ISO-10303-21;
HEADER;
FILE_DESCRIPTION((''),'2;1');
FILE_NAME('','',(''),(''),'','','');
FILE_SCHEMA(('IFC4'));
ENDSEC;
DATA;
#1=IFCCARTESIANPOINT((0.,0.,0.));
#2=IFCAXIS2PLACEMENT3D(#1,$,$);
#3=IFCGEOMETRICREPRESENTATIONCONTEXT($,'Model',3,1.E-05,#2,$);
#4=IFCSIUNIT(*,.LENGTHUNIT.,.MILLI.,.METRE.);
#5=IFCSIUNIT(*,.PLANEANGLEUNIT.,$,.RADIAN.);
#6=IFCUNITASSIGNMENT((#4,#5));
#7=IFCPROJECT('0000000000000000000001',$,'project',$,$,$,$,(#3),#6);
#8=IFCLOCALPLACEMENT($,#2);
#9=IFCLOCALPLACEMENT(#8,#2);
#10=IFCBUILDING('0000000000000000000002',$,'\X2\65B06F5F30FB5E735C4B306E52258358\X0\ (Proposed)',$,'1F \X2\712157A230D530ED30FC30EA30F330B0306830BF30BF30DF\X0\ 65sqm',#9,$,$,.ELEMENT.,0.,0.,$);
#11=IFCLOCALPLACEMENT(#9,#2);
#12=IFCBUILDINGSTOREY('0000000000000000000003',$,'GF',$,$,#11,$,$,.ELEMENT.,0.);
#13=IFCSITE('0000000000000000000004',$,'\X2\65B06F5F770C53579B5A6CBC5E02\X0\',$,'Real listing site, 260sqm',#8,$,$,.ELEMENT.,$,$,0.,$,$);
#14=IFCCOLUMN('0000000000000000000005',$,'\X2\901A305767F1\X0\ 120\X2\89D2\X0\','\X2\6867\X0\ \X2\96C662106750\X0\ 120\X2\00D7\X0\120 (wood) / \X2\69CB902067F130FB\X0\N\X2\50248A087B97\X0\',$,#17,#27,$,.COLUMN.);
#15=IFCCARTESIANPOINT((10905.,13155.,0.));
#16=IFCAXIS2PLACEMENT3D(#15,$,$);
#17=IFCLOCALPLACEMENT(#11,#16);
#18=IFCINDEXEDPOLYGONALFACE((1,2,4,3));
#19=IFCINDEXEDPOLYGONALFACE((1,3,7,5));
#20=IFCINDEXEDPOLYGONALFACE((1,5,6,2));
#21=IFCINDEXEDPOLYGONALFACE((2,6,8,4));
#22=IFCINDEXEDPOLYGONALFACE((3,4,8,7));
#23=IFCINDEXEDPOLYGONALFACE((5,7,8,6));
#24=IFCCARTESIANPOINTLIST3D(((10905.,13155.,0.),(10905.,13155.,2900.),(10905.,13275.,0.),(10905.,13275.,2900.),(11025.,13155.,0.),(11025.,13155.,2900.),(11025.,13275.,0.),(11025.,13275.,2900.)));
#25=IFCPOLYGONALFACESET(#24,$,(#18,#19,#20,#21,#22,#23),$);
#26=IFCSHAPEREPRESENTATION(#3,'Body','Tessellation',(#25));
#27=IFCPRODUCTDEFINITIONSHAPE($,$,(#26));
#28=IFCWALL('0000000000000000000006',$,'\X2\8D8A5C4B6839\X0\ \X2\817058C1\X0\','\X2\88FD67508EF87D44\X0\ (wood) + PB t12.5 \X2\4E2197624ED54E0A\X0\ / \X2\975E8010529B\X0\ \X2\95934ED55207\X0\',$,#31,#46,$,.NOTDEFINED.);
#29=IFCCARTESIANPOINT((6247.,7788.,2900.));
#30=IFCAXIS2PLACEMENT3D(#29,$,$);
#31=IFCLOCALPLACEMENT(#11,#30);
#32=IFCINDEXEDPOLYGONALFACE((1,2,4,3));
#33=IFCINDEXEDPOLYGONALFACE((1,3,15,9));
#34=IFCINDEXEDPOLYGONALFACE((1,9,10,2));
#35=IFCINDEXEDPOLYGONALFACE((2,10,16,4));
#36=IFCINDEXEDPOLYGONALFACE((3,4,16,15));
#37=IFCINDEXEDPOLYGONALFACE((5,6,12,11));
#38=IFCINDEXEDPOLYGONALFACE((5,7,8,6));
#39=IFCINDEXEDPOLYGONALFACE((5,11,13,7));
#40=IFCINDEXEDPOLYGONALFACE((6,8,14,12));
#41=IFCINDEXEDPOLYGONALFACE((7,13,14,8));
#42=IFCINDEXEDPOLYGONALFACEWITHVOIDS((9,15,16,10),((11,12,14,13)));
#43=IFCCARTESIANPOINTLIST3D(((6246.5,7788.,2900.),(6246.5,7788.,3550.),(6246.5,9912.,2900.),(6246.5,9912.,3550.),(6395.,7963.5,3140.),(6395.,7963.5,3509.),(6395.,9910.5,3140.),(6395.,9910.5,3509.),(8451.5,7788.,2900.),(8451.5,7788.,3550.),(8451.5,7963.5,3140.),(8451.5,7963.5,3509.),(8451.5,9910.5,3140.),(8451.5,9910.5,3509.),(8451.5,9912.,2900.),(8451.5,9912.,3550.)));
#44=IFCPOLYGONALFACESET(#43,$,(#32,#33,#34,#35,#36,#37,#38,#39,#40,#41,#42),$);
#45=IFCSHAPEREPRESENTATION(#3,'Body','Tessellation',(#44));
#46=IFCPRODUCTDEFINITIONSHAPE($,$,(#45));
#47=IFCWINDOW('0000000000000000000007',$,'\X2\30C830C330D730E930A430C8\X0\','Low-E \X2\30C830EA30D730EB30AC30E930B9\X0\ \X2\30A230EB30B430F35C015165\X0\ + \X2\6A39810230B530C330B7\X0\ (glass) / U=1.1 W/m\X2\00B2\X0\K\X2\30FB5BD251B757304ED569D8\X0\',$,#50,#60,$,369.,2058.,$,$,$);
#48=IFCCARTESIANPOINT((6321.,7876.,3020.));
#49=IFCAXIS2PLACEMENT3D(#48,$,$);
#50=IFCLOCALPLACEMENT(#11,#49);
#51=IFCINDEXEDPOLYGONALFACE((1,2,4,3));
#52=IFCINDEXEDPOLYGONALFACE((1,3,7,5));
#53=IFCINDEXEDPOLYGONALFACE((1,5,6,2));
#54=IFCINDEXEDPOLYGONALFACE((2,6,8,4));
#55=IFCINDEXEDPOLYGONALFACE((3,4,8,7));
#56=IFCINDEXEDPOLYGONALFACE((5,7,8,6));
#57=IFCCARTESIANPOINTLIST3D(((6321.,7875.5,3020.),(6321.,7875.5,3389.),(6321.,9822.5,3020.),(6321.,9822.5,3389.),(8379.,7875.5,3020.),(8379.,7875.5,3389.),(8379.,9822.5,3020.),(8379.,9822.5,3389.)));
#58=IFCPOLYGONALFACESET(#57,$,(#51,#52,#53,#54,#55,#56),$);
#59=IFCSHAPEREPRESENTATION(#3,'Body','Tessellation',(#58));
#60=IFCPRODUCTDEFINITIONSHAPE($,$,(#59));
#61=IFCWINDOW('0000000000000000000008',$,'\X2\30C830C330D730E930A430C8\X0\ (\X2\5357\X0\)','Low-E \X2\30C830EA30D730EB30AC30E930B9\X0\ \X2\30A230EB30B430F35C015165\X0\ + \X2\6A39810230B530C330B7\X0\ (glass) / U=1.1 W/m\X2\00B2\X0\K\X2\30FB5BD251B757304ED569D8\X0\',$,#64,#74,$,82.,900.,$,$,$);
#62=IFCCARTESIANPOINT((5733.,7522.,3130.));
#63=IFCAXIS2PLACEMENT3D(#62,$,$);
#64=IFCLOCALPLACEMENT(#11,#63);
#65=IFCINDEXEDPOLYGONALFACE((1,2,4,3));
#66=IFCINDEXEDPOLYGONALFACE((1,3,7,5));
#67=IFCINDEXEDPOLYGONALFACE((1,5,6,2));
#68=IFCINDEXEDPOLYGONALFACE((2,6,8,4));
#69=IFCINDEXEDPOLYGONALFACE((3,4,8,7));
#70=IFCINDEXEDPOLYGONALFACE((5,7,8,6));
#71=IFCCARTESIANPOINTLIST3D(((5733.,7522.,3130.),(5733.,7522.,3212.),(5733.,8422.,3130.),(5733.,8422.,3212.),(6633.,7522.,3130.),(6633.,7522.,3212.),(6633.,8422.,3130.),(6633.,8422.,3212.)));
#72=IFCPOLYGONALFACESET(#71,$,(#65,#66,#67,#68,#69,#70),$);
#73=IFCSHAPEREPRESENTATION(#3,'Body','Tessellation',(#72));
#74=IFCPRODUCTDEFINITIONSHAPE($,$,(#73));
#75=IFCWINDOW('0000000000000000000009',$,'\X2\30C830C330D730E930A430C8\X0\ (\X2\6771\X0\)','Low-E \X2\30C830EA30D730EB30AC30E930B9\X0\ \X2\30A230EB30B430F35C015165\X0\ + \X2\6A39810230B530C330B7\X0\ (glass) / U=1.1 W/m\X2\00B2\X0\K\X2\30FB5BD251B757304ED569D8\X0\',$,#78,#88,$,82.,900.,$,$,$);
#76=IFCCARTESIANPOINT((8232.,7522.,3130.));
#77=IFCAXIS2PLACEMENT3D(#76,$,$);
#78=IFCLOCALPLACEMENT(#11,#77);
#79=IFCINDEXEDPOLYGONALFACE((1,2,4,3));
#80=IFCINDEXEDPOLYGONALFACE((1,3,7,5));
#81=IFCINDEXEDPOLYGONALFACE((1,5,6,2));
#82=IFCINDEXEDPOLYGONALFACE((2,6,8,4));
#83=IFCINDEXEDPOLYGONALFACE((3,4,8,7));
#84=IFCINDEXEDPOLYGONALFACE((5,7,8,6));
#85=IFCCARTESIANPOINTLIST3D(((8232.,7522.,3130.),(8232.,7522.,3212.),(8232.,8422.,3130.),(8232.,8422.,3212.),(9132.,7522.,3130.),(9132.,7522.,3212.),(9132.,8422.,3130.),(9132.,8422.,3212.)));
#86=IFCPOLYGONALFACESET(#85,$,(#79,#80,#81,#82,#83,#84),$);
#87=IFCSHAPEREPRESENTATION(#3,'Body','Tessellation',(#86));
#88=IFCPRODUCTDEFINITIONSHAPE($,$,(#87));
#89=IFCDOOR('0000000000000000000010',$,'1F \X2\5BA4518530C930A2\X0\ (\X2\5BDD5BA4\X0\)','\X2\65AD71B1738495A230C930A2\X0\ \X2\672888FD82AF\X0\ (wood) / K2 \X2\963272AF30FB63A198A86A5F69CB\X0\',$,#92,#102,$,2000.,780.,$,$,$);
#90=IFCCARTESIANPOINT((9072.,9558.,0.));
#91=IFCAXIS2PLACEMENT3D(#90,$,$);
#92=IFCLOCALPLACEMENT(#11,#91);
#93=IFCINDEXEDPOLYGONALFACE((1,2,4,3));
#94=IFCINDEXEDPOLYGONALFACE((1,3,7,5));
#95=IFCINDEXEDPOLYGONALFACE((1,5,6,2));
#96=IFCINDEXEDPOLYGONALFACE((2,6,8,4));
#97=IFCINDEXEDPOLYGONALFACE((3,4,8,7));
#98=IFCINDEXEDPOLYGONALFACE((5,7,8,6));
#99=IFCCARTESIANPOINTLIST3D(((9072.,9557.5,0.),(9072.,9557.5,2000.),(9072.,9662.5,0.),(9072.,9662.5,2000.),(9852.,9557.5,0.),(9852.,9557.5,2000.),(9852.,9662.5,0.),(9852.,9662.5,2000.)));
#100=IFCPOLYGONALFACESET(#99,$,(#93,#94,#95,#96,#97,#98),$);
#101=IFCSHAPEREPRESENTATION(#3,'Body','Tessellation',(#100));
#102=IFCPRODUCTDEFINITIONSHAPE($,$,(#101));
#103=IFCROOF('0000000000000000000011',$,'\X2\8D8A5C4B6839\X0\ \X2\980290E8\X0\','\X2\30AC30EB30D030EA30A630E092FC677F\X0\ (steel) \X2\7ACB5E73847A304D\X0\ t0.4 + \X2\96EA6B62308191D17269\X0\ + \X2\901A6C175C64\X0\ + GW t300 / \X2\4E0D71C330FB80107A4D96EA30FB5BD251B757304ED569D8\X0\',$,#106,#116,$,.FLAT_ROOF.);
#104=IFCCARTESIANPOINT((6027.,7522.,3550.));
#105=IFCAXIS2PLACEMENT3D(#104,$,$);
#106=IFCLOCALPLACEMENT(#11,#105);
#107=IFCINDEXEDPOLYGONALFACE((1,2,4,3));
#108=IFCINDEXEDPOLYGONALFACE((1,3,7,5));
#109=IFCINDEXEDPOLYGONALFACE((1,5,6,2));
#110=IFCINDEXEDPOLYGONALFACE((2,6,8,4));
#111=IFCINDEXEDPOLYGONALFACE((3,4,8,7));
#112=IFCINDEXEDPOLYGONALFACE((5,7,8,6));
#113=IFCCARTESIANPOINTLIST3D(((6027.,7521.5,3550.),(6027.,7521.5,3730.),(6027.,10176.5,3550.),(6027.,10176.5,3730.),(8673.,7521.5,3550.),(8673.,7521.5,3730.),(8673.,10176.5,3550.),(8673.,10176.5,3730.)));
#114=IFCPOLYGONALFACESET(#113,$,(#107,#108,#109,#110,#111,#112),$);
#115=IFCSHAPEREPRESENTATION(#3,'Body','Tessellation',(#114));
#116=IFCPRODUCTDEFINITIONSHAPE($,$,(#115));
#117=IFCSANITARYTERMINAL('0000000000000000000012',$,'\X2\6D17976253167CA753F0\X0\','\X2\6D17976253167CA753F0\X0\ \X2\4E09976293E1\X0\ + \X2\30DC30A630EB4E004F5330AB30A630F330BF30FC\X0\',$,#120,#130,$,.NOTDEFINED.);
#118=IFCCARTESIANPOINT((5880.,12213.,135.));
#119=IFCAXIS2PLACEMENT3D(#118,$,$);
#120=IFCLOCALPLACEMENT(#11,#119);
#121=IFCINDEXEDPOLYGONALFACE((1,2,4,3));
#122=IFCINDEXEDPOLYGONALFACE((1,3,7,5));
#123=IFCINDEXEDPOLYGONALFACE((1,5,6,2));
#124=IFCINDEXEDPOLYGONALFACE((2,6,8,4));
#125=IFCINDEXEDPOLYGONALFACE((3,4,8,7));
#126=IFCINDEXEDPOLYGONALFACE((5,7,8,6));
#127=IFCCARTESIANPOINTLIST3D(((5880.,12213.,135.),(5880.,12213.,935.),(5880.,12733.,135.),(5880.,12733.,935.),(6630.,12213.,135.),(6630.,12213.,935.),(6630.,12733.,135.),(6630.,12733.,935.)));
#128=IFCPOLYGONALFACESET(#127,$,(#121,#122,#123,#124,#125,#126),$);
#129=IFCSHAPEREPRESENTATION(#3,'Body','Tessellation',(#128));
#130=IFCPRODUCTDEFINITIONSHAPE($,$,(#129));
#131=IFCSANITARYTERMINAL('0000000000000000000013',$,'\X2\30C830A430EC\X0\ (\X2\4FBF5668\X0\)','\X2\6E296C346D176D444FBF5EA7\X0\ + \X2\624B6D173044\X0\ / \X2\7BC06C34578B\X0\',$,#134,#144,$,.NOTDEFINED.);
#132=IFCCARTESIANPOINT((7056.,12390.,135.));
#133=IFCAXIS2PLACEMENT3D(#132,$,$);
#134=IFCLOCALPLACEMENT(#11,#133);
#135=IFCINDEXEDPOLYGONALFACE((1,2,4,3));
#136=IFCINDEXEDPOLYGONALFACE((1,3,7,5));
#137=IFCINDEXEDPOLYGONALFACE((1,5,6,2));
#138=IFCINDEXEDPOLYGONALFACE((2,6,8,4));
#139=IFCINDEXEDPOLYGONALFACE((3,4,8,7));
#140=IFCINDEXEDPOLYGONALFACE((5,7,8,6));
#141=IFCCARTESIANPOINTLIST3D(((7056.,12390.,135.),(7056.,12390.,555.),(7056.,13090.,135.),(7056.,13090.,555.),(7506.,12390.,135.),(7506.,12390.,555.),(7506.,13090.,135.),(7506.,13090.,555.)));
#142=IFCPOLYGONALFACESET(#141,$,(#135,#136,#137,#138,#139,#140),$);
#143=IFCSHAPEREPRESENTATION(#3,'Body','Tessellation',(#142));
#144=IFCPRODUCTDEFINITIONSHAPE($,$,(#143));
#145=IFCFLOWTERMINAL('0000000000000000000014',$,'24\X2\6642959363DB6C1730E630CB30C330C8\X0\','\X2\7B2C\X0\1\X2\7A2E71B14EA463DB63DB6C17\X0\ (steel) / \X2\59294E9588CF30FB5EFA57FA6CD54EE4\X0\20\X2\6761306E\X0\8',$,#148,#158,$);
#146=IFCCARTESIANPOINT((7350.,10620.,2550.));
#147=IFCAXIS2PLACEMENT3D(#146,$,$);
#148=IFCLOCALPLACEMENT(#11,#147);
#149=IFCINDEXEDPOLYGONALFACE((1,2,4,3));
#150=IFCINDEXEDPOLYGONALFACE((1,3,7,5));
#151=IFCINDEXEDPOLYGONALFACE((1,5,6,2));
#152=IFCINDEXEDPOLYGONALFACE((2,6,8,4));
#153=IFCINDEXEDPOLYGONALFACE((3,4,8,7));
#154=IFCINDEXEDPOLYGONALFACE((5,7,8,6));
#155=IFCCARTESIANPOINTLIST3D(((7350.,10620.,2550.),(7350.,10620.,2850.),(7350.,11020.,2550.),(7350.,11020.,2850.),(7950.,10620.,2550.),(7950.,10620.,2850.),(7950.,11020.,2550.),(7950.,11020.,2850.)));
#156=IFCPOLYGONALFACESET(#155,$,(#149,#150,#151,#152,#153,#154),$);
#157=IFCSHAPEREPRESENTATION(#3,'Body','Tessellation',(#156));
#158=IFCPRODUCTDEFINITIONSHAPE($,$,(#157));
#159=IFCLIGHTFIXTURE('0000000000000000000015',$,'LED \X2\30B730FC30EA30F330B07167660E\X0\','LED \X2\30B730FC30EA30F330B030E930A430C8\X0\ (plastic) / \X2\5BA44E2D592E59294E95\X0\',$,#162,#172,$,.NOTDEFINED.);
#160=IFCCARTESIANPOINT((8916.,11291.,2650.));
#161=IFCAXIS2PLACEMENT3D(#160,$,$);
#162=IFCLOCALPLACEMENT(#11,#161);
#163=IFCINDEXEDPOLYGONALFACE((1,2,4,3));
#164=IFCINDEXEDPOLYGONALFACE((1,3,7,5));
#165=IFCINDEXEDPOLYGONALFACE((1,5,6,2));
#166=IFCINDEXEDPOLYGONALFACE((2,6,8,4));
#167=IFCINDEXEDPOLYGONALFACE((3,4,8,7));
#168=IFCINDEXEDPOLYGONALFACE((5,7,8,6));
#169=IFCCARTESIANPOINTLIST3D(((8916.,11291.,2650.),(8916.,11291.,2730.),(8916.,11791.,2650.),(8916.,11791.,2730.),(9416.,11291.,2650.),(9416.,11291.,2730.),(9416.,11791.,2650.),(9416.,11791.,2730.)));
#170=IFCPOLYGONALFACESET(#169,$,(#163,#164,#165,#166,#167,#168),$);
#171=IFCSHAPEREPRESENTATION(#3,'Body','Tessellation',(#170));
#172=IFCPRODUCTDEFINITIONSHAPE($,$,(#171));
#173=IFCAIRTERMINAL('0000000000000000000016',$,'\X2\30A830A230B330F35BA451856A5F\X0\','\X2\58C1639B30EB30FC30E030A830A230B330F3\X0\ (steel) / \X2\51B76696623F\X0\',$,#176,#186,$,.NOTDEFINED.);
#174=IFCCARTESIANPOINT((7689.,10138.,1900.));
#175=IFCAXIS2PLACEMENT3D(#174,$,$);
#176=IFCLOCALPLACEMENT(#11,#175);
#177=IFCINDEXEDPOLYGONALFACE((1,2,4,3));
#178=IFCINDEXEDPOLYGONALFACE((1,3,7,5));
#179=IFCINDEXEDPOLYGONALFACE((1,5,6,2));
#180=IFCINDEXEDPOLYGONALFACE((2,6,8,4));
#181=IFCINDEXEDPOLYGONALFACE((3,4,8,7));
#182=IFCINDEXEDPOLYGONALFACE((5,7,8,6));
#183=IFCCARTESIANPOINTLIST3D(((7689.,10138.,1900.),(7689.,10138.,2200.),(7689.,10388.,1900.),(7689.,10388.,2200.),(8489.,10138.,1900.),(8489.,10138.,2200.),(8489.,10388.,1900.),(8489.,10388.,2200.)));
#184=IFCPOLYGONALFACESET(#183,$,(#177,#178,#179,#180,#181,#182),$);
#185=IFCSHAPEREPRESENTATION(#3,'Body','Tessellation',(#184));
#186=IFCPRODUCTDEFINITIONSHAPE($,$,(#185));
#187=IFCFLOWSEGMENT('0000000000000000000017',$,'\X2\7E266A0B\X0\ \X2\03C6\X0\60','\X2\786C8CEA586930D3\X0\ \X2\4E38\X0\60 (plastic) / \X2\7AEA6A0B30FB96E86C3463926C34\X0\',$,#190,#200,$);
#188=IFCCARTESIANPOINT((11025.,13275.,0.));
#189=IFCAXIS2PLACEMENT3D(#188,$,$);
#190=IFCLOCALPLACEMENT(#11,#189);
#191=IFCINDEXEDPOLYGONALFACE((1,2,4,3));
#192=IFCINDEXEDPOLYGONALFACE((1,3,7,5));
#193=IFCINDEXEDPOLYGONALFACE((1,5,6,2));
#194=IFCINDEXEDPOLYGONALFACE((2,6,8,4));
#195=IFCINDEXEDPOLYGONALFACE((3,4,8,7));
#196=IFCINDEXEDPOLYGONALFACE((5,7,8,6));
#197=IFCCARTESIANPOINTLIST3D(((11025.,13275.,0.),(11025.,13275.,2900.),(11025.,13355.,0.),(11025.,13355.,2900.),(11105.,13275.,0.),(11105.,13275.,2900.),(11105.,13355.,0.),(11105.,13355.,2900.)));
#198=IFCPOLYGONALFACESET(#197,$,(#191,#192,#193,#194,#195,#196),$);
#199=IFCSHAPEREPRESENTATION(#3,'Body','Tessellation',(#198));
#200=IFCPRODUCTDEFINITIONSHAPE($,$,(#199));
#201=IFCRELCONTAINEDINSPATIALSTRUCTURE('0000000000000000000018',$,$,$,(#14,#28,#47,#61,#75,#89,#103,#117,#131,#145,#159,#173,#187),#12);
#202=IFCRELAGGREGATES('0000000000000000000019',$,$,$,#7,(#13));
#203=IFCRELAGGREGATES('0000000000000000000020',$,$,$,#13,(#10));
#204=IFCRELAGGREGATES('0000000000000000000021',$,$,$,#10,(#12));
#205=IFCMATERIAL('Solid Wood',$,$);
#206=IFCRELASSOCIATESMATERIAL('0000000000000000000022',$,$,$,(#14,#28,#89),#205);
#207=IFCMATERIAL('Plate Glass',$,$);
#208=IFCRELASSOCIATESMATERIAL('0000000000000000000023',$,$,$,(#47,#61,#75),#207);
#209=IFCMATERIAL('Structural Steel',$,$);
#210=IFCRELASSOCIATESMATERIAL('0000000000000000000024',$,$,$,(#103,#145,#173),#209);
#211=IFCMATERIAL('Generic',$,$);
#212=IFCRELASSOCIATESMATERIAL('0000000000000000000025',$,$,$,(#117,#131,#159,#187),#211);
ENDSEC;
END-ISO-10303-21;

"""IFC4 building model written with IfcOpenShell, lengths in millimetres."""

from ifc_helpers import new_model, si_unit, frame, frame_2d, origin, place, context, project, spatial, rectangle, extrude, material, element, fill, save


model = new_model("IFC4")

# Units and contexts
model_context = context("Model", 3, precision=1e-05, world=origin())
ifc_project = project(units=[si_unit("LENGTHUNIT", "METRE", prefix="MILLI"), si_unit("PLANEANGLEUNIT", "RADIAN")], contexts=[model_context])

# Site, building, storey
site_placement = place(None, origin())
site = spatial("IfcSite", under=ifc_project, at=site_placement, Name="新潟県南魚沼市", ObjectType="Real listing site, 260sqm", CompositionType="ELEMENT", RefElevation=0.0)
building_placement = place(site_placement, origin())
building = spatial("IfcBuilding", under=site, at=building_placement, Name="新潟・平屋の別荘 (Proposed)", ObjectType="1F 無垢フローリングとタタミ 65sqm", CompositionType="ELEMENT", ElevationOfRefHeight=0.0, ElevationOfTerrain=0.0)
storey_placement = place(building_placement, origin())
storey = spatial("IfcBuildingStorey", under=building, at=storey_placement, Name="GF", CompositionType="ELEMENT", Elevation=0.0)

# Column
ifc_material_1 = material(Name="Solid Wood")
column_1_placement = place(storey_placement, frame((10905.0, 13155.0, 0.0)))
element("IfcColumn", 1, at=column_1_placement, inside=storey, material=ifc_material_1, Name="通し柱 120角", Description="桧 集成材 120×120 (wood) / 構造柱・N値計算", PredefinedType="COLUMN", context=model_context, shape_type="SweptSolid", body=[
    extrude(rectangle(XDim=120.0, YDim=120.0, at=frame_2d((60.0, 60.0))), frame((10905.0, 13155.0, 0.0)), (0.0, 0.0, 1.0), 2900.0),
])

# Wall, openings, windows
wall_1_placement = place(storey_placement, frame((6247.0, 7788.0, 2900.0)))
wall_1 = element("IfcWall", 2, at=wall_1_placement, inside=storey, material=ifc_material_1, Name="越屋根 腰壁", Description="製材軸組 (wood) + PB t12.5 両面仕上 / 非耐力 間仕切", PredefinedType="NOTDEFINED", context=model_context, shape_type="SweptSolid", body=[
    extrude(rectangle(XDim=2205.0, YDim=2124.0, at=frame_2d((1102.0, 1062.0))), frame((6247.0, 7788.0, 2900.0)), (0.0, 0.0, 1.0), 650.0),
])
opening_1_placement = place(storey_placement, frame((6321.0, 7876.0, 3020.0)))
opening_1 = element("IfcOpeningElement", 3, at=opening_1_placement, cuts=wall_1, PredefinedType="NOTDEFINED", context=model_context, shape_type="SweptSolid", body=[
    extrude(rectangle(XDim=2058.0, YDim=1947.0, at=frame_2d((1029.0, 973.0))), frame((6321.0, 7876.0, 3020.0)), (0.0, 0.0, 1.0), 369.0),
])
opening_2_placement = place(storey_placement, frame((5733.0, 7522.0, 3130.0)))
opening_2 = element("IfcOpeningElement", 4, at=opening_2_placement, cuts=wall_1, PredefinedType="NOTDEFINED", context=model_context, shape_type="SweptSolid", body=[
    extrude(rectangle(XDim=900.0, YDim=900.0, at=frame_2d((450.0, 450.0))), frame((5733.0, 7522.0, 3130.0)), (0.0, 0.0, 1.0), 82.0),
])
opening_3_placement = place(storey_placement, frame((8232.0, 7522.0, 3130.0)))
opening_3 = element("IfcOpeningElement", 5, at=opening_3_placement, cuts=wall_1, PredefinedType="NOTDEFINED", context=model_context, shape_type="SweptSolid", body=[
    extrude(rectangle(XDim=900.0, YDim=900.0, at=frame_2d((450.0, 450.0))), frame((8232.0, 7522.0, 3130.0)), (0.0, 0.0, 1.0), 82.0),
])
ifc_material_2 = material(Name="Plate Glass")
window_1_placement = place(storey_placement, frame((6321.0, 7876.0, 3020.0)))
window_1 = element("IfcWindow", 6, at=window_1_placement, inside=storey, material=ifc_material_2, Name="トップライト", Description="Low-E トリプルガラス アルゴン封入 + 樹脂サッシ (glass) / U=1.1 W/m²K・寒冷地仕様", OverallHeight=369.0, OverallWidth=2058.0, context=model_context, shape_type="SweptSolid", body=[
    extrude(rectangle(XDim=2058.0, YDim=1947.0, at=frame_2d((1029.0, 973.0))), frame((6321.0, 7876.0, 3020.0)), (0.0, 0.0, 1.0), 369.0),
])
fill(opening_1, window_1)
window_2_placement = place(storey_placement, frame((5733.0, 7522.0, 3130.0)))
window_2 = element("IfcWindow", 7, at=window_2_placement, inside=storey, material=ifc_material_2, Name="トップライト (南)", Description="Low-E トリプルガラス アルゴン封入 + 樹脂サッシ (glass) / U=1.1 W/m²K・寒冷地仕様", OverallHeight=82.0, OverallWidth=900.0, context=model_context, shape_type="SweptSolid", body=[
    extrude(rectangle(XDim=900.0, YDim=900.0, at=frame_2d((450.0, 450.0))), frame((5733.0, 7522.0, 3130.0)), (0.0, 0.0, 1.0), 82.0),
])
fill(opening_2, window_2)
window_3_placement = place(storey_placement, frame((8232.0, 7522.0, 3130.0)))
window_3 = element("IfcWindow", 8, at=window_3_placement, inside=storey, material=ifc_material_2, Name="トップライト (東)", Description="Low-E トリプルガラス アルゴン封入 + 樹脂サッシ (glass) / U=1.1 W/m²K・寒冷地仕様", OverallHeight=82.0, OverallWidth=900.0, context=model_context, shape_type="SweptSolid", body=[
    extrude(rectangle(XDim=900.0, YDim=900.0, at=frame_2d((450.0, 450.0))), frame((8232.0, 7522.0, 3130.0)), (0.0, 0.0, 1.0), 82.0),
])
fill(opening_3, window_3)

# Door
door_placement = place(storey_placement, frame((9072.0, 9558.0, 0.0)))
element("IfcDoor", 9, at=door_placement, inside=storey, material=ifc_material_1, Name="1F 室内ドア (寝室)", Description="断熱玄関ドア 木製芯 (wood) / K2 防犯・採風機構", OverallHeight=2000.0, OverallWidth=780.0, context=model_context, shape_type="SweptSolid", body=[
    extrude(rectangle(XDim=780.0, YDim=105.0, at=frame_2d((390.0, 52.0))), frame((9072.0, 9558.0, 0.0)), (0.0, 0.0, 1.0), 2000.0),
])

# Roof
ifc_material_3 = material(Name="Structural Steel")
roof_placement = place(storey_placement, frame((6027.0, 7522.0, 3550.0)))
element("IfcRoof", 10, at=roof_placement, inside=storey, material=ifc_material_3, Name="越屋根 頂部", Description="ガルバリウム鋼板 (steel) 立平葺き t0.4 + 雪止め金物 + 通気層 + GW t300 / 不燃・耐積雪・寒冷地仕様", PredefinedType="FLAT_ROOF", context=model_context, shape_type="SweptSolid", body=[
    extrude(rectangle(XDim=2646.0, YDim=2655.0, at=frame_2d((1323.0, 1327.0))), frame((6027.0, 7522.0, 3550.0)), (0.0, 0.0, 1.0), 180.0),
])

# Sanitary terminals
ifc_material_4 = material(Name="Generic")
sanitary_terminal_1_placement = place(storey_placement, frame((5880.0, 12213.0, 135.0)))
element("IfcSanitaryTerminal", 11, at=sanitary_terminal_1_placement, inside=storey, material=ifc_material_4, Name="洗面化粧台", Description="洗面化粧台 三面鏡 + ボウル一体カウンター", PredefinedType="NOTDEFINED", context=model_context, shape_type="SweptSolid", body=[
    extrude(rectangle(XDim=750.0, YDim=520.0, at=frame_2d((375.0, 260.0))), frame((5880.0, 12213.0, 135.0)), (0.0, 0.0, 1.0), 800.0),
])
sanitary_terminal_2_placement = place(storey_placement, frame((7056.0, 12390.0, 135.0)))
element("IfcSanitaryTerminal", 12, at=sanitary_terminal_2_placement, inside=storey, material=ifc_material_4, Name="トイレ (便器)", Description="温水洗浄便座 + 手洗い / 節水型", PredefinedType="NOTDEFINED", context=model_context, shape_type="SweptSolid", body=[
    extrude(rectangle(XDim=450.0, YDim=700.0, at=frame_2d((225.0, 350.0))), frame((7056.0, 12390.0, 135.0)), (0.0, 0.0, 1.0), 420.0),
])

# Flow terminal
flow_terminal_placement = place(storey_placement, frame((7350.0, 10620.0, 2550.0)))
element("IfcFlowTerminal", 13, at=flow_terminal_placement, inside=storey, material=ifc_material_3, Name="24時間換気ユニット", Description="第1種熱交換換気 (steel) / 天井裏・建基法令20条の8", context=model_context, shape_type="SweptSolid", body=[
    extrude(rectangle(XDim=600.0, YDim=400.0, at=frame_2d((300.0, 200.0))), frame((7350.0, 10620.0, 2550.0)), (0.0, 0.0, 1.0), 300.0),
])

# Light fixture
light_fixture_placement = place(storey_placement, frame((8916.0, 11291.0, 2650.0)))
element("IfcLightFixture", 14, at=light_fixture_placement, inside=storey, material=ifc_material_4, Name="LED シーリング照明", Description="LED シーリングライト (plastic) / 室中央天井", PredefinedType="NOTDEFINED", context=model_context, shape_type="SweptSolid", body=[
    extrude(rectangle(XDim=500.0, YDim=500.0, at=frame_2d((250.0, 250.0))), frame((8916.0, 11291.0, 2650.0)), (0.0, 0.0, 1.0), 80.0),
])

# Air terminal
air_terminal_placement = place(storey_placement, frame((7689.0, 10138.0, 1900.0)))
element("IfcAirTerminal", 15, at=air_terminal_placement, inside=storey, material=ifc_material_3, Name="エアコン室内機", Description="壁掛ルームエアコン (steel) / 冷暖房", PredefinedType="NOTDEFINED", context=model_context, shape_type="SweptSolid", body=[
    extrude(rectangle(XDim=800.0, YDim=250.0, at=frame_2d((400.0, 125.0))), frame((7689.0, 10138.0, 1900.0)), (0.0, 0.0, 1.0), 300.0),
])

# Flow segment
flow_segment_placement = place(storey_placement, frame((11025.0, 13275.0, 0.0)))
element("IfcFlowSegment", 16, at=flow_segment_placement, inside=storey, material=ifc_material_4, Name="縦樋 φ60", Description="硬質塩ビ 丸60 (plastic) / 竪樋・雨水排水", context=model_context, shape_type="SweptSolid", body=[
    extrude(rectangle(XDim=80.0, YDim=80.0, at=frame_2d((40.0, 40.0))), frame((11025.0, 13275.0, 0.0)), (0.0, 0.0, 1.0), 2900.0),
])

save(model, "model.ifc")
